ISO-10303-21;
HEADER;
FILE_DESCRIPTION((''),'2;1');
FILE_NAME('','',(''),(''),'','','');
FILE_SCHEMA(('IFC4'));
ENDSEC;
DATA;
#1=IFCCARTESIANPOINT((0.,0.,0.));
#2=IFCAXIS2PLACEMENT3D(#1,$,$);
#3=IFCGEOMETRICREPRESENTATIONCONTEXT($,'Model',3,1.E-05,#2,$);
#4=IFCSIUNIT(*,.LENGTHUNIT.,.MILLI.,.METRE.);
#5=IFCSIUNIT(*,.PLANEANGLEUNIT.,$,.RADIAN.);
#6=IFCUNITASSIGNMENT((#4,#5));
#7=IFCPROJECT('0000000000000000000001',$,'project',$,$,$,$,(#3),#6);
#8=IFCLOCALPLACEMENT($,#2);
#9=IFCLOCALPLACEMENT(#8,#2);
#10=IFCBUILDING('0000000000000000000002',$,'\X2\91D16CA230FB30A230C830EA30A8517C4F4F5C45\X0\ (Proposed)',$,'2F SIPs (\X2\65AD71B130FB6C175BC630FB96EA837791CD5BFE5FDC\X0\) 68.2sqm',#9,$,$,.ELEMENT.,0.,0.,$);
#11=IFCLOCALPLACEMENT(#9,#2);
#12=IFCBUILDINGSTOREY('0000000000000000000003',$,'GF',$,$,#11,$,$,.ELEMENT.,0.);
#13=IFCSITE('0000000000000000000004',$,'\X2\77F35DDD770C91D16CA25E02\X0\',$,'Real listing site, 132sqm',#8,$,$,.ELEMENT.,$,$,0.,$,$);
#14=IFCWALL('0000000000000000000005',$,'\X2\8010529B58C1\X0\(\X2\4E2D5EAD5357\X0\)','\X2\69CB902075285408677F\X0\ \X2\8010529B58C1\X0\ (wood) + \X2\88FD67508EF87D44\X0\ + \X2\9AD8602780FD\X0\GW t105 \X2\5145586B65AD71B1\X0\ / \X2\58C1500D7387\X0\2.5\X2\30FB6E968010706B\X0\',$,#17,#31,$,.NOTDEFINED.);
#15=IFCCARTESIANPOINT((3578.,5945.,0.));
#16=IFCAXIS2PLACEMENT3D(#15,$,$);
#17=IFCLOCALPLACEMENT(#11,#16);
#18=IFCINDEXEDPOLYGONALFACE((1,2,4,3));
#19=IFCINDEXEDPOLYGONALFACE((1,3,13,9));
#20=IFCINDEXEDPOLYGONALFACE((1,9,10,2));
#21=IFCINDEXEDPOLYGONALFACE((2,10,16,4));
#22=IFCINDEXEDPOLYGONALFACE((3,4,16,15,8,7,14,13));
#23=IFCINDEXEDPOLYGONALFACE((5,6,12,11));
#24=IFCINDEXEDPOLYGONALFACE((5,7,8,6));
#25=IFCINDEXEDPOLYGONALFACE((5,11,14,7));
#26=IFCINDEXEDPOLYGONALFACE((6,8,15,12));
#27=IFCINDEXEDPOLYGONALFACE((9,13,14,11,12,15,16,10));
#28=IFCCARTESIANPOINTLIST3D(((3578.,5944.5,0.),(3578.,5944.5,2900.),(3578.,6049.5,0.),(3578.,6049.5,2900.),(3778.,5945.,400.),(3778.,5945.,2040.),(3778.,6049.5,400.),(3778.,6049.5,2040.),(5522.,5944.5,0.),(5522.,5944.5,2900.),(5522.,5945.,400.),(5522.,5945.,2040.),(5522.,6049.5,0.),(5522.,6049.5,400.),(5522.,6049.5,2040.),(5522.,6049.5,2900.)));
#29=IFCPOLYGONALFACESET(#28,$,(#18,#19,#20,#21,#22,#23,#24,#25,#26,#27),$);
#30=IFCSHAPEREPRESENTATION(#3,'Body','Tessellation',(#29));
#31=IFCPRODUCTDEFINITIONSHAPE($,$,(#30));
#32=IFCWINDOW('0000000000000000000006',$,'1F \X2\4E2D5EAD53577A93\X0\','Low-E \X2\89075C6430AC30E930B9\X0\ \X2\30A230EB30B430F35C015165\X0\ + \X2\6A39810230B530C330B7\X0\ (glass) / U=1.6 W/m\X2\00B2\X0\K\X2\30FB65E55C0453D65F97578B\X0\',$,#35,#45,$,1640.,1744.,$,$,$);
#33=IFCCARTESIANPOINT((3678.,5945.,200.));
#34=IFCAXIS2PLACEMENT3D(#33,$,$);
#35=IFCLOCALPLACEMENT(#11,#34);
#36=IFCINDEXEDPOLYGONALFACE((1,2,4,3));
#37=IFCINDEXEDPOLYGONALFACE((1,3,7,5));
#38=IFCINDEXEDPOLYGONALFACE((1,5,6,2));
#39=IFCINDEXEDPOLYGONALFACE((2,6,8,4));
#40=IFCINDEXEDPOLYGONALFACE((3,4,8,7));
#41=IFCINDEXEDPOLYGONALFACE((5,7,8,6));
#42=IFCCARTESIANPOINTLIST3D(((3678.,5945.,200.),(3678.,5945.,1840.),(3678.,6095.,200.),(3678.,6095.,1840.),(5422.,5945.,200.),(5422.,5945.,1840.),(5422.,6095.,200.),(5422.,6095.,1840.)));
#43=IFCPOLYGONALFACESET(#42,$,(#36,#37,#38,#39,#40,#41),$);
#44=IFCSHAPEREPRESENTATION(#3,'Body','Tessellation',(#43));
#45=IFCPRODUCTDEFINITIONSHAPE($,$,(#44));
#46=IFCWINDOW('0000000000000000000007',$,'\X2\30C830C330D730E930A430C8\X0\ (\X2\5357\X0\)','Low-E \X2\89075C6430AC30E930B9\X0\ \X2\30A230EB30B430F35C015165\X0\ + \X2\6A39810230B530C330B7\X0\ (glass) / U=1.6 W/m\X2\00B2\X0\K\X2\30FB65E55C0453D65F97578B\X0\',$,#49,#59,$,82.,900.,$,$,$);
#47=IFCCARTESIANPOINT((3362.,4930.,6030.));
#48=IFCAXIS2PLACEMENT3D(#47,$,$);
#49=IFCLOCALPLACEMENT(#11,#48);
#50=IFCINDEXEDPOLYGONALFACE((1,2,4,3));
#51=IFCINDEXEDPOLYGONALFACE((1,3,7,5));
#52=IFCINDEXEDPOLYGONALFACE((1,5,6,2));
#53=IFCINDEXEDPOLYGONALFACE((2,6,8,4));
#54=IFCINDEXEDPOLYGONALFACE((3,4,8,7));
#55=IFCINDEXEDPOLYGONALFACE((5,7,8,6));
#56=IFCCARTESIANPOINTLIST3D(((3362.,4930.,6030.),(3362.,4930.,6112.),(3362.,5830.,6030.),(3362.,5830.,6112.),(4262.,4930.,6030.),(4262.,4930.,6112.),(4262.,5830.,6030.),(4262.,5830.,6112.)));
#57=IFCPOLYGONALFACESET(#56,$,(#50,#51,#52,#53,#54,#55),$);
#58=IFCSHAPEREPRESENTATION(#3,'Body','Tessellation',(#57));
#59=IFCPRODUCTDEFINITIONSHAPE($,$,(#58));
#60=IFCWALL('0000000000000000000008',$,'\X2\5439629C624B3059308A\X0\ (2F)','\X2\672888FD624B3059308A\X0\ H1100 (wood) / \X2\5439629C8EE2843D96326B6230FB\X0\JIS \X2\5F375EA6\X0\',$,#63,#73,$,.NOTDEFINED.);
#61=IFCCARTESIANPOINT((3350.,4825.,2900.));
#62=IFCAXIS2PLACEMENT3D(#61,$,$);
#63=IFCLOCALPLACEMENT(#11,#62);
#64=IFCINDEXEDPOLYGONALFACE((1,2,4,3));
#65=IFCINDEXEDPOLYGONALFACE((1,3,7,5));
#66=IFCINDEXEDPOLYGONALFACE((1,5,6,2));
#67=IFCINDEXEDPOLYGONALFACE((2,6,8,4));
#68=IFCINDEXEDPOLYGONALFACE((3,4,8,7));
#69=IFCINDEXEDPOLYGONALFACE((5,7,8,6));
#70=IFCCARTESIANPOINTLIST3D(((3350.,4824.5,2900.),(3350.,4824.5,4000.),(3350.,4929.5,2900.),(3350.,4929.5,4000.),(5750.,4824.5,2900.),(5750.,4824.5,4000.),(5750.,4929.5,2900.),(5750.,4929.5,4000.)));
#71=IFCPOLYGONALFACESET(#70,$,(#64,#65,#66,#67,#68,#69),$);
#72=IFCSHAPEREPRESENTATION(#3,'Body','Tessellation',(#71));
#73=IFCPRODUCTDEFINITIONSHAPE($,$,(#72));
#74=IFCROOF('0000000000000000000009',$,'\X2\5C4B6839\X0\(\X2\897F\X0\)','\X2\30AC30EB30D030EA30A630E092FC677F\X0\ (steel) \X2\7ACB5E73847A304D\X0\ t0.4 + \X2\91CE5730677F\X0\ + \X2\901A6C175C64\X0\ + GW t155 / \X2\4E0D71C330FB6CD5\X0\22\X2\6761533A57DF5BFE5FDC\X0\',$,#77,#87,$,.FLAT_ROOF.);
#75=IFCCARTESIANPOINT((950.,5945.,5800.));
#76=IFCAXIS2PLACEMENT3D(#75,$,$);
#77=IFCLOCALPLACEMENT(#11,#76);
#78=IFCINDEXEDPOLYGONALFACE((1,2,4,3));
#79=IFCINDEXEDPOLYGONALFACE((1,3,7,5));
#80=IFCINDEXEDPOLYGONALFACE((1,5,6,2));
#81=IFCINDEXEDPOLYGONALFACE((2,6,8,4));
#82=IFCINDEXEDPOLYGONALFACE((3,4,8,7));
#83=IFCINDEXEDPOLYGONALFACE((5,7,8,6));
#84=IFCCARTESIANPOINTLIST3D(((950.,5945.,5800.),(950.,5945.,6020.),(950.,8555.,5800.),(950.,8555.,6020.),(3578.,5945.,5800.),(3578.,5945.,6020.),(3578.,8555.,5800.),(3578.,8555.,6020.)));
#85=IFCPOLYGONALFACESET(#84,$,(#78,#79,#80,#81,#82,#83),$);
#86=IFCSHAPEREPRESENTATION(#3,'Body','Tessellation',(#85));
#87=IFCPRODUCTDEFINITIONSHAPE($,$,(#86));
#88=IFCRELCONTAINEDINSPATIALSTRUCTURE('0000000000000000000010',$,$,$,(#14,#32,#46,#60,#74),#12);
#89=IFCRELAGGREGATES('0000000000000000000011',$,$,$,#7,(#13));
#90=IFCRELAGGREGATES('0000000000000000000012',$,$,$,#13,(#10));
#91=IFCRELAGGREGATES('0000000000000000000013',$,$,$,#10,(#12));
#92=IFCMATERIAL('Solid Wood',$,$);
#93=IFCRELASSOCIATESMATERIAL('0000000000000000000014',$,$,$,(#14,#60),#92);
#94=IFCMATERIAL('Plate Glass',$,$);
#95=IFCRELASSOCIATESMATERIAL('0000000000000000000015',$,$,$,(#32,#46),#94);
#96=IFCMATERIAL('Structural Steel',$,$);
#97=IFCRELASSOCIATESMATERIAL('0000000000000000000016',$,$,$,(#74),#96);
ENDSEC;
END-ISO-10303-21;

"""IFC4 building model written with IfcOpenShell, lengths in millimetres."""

from ifc_helpers import new_model, si_unit, frame, frame_2d, origin, place, context, project, spatial, rectangle, extrude, material, element, fill, save


model = new_model("IFC4")

# Units and contexts
model_context = context("Model", 3, precision=1e-05, world=origin())
ifc_project = project(units=[si_unit("LENGTHUNIT", "METRE", prefix="MILLI"), si_unit("PLANEANGLEUNIT", "RADIAN")], contexts=[model_context])

# Site, building, storey
site_placement = place(None, origin())
site = spatial("IfcSite", under=ifc_project, at=site_placement, Name="石川県金沢市", ObjectType="Real listing site, 132sqm", CompositionType="ELEMENT", RefElevation=0.0)
building_placement = place(site_placement, origin())
building = spatial("IfcBuilding", under=site, at=building_placement, Name="金沢・アトリエ兼住居 (Proposed)", ObjectType="2F SIPs (断熱・気密・雪荷重対応) 68.2sqm", CompositionType="ELEMENT", ElevationOfRefHeight=0.0, ElevationOfTerrain=0.0)
storey_placement = place(building_placement, origin())
storey = spatial("IfcBuildingStorey", under=building, at=storey_placement, Name="GF", CompositionType="ELEMENT", Elevation=0.0)

# Shared definitions
ifc_material_1 = material(Name="Solid Wood")

# Wall, opening, window
wall_1_placement = place(storey_placement, frame((3578.0, 5945.0, 0.0)))
wall_1 = element("IfcWall", 1, at=wall_1_placement, inside=storey, material=ifc_material_1, Name="耐力壁(中庭南)", Description="構造用合板 耐力壁 (wood) + 製材軸組 + 高性能GW t105 充填断熱 / 壁倍率2.5・準耐火", PredefinedType="NOTDEFINED", context=model_context, shape_type="SweptSolid", body=[
    extrude(rectangle(XDim=1944.0, YDim=105.0, at=frame_2d((972.0, 52.0))), frame((3578.0, 5945.0, 0.0)), (0.0, 0.0, 1.0), 2900.0),
])
opening_placement = place(storey_placement, frame((3678.0, 5945.0, 200.0)))
opening = element("IfcOpeningElement", 2, at=opening_placement, cuts=wall_1, PredefinedType="NOTDEFINED", context=model_context, shape_type="SweptSolid", body=[
    extrude(rectangle(XDim=1744.0, YDim=150.0, at=frame_2d((872.0, 75.0))), frame((3678.0, 5945.0, 200.0)), (0.0, 0.0, 1.0), 1640.0),
])
ifc_material_2 = material(Name="Plate Glass")
window_1_placement = place(storey_placement, frame((3678.0, 5945.0, 200.0)))
window_1 = element("IfcWindow", 3, at=window_1_placement, inside=storey, material=ifc_material_2, Name="1F 中庭南窓", Description="Low-E 複層ガラス アルゴン封入 + 樹脂サッシ (glass) / U=1.6 W/m²K・日射取得型", OverallHeight=1640.0, OverallWidth=1744.0, context=model_context, shape_type="SweptSolid", body=[
    extrude(rectangle(XDim=1744.0, YDim=150.0, at=frame_2d((872.0, 75.0))), frame((3678.0, 5945.0, 200.0)), (0.0, 0.0, 1.0), 1640.0),
])
fill(opening, window_1)

# Window
window_2_placement = place(storey_placement, frame((3362.0, 4930.0, 6030.0)))
element("IfcWindow", 4, at=window_2_placement, inside=storey, material=ifc_material_2, Name="トップライト (南)", Description="Low-E 複層ガラス アルゴン封入 + 樹脂サッシ (glass) / U=1.6 W/m²K・日射取得型", OverallHeight=82.0, OverallWidth=900.0, context=model_context, shape_type="SweptSolid", body=[
    extrude(rectangle(XDim=900.0, YDim=900.0, at=frame_2d((450.0, 450.0))), frame((3362.0, 4930.0, 6030.0)), (0.0, 0.0, 1.0), 82.0),
])

# Wall
wall_2_placement = place(storey_placement, frame((3350.0, 4825.0, 2900.0)))
element("IfcWall", 5, at=wall_2_placement, inside=storey, material=ifc_material_1, Name="吹抜手すり (2F)", Description="木製手すり H1100 (wood) / 吹抜転落防止・JIS 強度", PredefinedType="NOTDEFINED", context=model_context, shape_type="SweptSolid", body=[
    extrude(rectangle(XDim=2400.0, YDim=105.0, at=frame_2d((1200.0, 52.0))), frame((3350.0, 4825.0, 2900.0)), (0.0, 0.0, 1.0), 1100.0),
])

# Roof
ifc_material_3 = material(Name="Structural Steel")
for number, where, name in (
    (6, (950.0, 5945.0, 5800.0), "屋根(西)"),
):
    element("IfcRoof", number, at=place(storey_placement, frame(where)), inside=storey, material=ifc_material_3, Name=name, Description="ガルバリウム鋼板 (steel) 立平葺き t0.4 + 野地板 + 通気層 + GW t155 / 不燃・法22条区域対応", PredefinedType="FLAT_ROOF", context=model_context, shape_type="SweptSolid", body=[
        extrude(rectangle(XDim=2628.0, YDim=2610.0, at=frame_2d((1314.0, 1305.0))), frame((950.0, 5945.0, 5800.0)), (0.0, 0.0, 1.0), 220.0),
    ])

save(model, "model.ifc")
